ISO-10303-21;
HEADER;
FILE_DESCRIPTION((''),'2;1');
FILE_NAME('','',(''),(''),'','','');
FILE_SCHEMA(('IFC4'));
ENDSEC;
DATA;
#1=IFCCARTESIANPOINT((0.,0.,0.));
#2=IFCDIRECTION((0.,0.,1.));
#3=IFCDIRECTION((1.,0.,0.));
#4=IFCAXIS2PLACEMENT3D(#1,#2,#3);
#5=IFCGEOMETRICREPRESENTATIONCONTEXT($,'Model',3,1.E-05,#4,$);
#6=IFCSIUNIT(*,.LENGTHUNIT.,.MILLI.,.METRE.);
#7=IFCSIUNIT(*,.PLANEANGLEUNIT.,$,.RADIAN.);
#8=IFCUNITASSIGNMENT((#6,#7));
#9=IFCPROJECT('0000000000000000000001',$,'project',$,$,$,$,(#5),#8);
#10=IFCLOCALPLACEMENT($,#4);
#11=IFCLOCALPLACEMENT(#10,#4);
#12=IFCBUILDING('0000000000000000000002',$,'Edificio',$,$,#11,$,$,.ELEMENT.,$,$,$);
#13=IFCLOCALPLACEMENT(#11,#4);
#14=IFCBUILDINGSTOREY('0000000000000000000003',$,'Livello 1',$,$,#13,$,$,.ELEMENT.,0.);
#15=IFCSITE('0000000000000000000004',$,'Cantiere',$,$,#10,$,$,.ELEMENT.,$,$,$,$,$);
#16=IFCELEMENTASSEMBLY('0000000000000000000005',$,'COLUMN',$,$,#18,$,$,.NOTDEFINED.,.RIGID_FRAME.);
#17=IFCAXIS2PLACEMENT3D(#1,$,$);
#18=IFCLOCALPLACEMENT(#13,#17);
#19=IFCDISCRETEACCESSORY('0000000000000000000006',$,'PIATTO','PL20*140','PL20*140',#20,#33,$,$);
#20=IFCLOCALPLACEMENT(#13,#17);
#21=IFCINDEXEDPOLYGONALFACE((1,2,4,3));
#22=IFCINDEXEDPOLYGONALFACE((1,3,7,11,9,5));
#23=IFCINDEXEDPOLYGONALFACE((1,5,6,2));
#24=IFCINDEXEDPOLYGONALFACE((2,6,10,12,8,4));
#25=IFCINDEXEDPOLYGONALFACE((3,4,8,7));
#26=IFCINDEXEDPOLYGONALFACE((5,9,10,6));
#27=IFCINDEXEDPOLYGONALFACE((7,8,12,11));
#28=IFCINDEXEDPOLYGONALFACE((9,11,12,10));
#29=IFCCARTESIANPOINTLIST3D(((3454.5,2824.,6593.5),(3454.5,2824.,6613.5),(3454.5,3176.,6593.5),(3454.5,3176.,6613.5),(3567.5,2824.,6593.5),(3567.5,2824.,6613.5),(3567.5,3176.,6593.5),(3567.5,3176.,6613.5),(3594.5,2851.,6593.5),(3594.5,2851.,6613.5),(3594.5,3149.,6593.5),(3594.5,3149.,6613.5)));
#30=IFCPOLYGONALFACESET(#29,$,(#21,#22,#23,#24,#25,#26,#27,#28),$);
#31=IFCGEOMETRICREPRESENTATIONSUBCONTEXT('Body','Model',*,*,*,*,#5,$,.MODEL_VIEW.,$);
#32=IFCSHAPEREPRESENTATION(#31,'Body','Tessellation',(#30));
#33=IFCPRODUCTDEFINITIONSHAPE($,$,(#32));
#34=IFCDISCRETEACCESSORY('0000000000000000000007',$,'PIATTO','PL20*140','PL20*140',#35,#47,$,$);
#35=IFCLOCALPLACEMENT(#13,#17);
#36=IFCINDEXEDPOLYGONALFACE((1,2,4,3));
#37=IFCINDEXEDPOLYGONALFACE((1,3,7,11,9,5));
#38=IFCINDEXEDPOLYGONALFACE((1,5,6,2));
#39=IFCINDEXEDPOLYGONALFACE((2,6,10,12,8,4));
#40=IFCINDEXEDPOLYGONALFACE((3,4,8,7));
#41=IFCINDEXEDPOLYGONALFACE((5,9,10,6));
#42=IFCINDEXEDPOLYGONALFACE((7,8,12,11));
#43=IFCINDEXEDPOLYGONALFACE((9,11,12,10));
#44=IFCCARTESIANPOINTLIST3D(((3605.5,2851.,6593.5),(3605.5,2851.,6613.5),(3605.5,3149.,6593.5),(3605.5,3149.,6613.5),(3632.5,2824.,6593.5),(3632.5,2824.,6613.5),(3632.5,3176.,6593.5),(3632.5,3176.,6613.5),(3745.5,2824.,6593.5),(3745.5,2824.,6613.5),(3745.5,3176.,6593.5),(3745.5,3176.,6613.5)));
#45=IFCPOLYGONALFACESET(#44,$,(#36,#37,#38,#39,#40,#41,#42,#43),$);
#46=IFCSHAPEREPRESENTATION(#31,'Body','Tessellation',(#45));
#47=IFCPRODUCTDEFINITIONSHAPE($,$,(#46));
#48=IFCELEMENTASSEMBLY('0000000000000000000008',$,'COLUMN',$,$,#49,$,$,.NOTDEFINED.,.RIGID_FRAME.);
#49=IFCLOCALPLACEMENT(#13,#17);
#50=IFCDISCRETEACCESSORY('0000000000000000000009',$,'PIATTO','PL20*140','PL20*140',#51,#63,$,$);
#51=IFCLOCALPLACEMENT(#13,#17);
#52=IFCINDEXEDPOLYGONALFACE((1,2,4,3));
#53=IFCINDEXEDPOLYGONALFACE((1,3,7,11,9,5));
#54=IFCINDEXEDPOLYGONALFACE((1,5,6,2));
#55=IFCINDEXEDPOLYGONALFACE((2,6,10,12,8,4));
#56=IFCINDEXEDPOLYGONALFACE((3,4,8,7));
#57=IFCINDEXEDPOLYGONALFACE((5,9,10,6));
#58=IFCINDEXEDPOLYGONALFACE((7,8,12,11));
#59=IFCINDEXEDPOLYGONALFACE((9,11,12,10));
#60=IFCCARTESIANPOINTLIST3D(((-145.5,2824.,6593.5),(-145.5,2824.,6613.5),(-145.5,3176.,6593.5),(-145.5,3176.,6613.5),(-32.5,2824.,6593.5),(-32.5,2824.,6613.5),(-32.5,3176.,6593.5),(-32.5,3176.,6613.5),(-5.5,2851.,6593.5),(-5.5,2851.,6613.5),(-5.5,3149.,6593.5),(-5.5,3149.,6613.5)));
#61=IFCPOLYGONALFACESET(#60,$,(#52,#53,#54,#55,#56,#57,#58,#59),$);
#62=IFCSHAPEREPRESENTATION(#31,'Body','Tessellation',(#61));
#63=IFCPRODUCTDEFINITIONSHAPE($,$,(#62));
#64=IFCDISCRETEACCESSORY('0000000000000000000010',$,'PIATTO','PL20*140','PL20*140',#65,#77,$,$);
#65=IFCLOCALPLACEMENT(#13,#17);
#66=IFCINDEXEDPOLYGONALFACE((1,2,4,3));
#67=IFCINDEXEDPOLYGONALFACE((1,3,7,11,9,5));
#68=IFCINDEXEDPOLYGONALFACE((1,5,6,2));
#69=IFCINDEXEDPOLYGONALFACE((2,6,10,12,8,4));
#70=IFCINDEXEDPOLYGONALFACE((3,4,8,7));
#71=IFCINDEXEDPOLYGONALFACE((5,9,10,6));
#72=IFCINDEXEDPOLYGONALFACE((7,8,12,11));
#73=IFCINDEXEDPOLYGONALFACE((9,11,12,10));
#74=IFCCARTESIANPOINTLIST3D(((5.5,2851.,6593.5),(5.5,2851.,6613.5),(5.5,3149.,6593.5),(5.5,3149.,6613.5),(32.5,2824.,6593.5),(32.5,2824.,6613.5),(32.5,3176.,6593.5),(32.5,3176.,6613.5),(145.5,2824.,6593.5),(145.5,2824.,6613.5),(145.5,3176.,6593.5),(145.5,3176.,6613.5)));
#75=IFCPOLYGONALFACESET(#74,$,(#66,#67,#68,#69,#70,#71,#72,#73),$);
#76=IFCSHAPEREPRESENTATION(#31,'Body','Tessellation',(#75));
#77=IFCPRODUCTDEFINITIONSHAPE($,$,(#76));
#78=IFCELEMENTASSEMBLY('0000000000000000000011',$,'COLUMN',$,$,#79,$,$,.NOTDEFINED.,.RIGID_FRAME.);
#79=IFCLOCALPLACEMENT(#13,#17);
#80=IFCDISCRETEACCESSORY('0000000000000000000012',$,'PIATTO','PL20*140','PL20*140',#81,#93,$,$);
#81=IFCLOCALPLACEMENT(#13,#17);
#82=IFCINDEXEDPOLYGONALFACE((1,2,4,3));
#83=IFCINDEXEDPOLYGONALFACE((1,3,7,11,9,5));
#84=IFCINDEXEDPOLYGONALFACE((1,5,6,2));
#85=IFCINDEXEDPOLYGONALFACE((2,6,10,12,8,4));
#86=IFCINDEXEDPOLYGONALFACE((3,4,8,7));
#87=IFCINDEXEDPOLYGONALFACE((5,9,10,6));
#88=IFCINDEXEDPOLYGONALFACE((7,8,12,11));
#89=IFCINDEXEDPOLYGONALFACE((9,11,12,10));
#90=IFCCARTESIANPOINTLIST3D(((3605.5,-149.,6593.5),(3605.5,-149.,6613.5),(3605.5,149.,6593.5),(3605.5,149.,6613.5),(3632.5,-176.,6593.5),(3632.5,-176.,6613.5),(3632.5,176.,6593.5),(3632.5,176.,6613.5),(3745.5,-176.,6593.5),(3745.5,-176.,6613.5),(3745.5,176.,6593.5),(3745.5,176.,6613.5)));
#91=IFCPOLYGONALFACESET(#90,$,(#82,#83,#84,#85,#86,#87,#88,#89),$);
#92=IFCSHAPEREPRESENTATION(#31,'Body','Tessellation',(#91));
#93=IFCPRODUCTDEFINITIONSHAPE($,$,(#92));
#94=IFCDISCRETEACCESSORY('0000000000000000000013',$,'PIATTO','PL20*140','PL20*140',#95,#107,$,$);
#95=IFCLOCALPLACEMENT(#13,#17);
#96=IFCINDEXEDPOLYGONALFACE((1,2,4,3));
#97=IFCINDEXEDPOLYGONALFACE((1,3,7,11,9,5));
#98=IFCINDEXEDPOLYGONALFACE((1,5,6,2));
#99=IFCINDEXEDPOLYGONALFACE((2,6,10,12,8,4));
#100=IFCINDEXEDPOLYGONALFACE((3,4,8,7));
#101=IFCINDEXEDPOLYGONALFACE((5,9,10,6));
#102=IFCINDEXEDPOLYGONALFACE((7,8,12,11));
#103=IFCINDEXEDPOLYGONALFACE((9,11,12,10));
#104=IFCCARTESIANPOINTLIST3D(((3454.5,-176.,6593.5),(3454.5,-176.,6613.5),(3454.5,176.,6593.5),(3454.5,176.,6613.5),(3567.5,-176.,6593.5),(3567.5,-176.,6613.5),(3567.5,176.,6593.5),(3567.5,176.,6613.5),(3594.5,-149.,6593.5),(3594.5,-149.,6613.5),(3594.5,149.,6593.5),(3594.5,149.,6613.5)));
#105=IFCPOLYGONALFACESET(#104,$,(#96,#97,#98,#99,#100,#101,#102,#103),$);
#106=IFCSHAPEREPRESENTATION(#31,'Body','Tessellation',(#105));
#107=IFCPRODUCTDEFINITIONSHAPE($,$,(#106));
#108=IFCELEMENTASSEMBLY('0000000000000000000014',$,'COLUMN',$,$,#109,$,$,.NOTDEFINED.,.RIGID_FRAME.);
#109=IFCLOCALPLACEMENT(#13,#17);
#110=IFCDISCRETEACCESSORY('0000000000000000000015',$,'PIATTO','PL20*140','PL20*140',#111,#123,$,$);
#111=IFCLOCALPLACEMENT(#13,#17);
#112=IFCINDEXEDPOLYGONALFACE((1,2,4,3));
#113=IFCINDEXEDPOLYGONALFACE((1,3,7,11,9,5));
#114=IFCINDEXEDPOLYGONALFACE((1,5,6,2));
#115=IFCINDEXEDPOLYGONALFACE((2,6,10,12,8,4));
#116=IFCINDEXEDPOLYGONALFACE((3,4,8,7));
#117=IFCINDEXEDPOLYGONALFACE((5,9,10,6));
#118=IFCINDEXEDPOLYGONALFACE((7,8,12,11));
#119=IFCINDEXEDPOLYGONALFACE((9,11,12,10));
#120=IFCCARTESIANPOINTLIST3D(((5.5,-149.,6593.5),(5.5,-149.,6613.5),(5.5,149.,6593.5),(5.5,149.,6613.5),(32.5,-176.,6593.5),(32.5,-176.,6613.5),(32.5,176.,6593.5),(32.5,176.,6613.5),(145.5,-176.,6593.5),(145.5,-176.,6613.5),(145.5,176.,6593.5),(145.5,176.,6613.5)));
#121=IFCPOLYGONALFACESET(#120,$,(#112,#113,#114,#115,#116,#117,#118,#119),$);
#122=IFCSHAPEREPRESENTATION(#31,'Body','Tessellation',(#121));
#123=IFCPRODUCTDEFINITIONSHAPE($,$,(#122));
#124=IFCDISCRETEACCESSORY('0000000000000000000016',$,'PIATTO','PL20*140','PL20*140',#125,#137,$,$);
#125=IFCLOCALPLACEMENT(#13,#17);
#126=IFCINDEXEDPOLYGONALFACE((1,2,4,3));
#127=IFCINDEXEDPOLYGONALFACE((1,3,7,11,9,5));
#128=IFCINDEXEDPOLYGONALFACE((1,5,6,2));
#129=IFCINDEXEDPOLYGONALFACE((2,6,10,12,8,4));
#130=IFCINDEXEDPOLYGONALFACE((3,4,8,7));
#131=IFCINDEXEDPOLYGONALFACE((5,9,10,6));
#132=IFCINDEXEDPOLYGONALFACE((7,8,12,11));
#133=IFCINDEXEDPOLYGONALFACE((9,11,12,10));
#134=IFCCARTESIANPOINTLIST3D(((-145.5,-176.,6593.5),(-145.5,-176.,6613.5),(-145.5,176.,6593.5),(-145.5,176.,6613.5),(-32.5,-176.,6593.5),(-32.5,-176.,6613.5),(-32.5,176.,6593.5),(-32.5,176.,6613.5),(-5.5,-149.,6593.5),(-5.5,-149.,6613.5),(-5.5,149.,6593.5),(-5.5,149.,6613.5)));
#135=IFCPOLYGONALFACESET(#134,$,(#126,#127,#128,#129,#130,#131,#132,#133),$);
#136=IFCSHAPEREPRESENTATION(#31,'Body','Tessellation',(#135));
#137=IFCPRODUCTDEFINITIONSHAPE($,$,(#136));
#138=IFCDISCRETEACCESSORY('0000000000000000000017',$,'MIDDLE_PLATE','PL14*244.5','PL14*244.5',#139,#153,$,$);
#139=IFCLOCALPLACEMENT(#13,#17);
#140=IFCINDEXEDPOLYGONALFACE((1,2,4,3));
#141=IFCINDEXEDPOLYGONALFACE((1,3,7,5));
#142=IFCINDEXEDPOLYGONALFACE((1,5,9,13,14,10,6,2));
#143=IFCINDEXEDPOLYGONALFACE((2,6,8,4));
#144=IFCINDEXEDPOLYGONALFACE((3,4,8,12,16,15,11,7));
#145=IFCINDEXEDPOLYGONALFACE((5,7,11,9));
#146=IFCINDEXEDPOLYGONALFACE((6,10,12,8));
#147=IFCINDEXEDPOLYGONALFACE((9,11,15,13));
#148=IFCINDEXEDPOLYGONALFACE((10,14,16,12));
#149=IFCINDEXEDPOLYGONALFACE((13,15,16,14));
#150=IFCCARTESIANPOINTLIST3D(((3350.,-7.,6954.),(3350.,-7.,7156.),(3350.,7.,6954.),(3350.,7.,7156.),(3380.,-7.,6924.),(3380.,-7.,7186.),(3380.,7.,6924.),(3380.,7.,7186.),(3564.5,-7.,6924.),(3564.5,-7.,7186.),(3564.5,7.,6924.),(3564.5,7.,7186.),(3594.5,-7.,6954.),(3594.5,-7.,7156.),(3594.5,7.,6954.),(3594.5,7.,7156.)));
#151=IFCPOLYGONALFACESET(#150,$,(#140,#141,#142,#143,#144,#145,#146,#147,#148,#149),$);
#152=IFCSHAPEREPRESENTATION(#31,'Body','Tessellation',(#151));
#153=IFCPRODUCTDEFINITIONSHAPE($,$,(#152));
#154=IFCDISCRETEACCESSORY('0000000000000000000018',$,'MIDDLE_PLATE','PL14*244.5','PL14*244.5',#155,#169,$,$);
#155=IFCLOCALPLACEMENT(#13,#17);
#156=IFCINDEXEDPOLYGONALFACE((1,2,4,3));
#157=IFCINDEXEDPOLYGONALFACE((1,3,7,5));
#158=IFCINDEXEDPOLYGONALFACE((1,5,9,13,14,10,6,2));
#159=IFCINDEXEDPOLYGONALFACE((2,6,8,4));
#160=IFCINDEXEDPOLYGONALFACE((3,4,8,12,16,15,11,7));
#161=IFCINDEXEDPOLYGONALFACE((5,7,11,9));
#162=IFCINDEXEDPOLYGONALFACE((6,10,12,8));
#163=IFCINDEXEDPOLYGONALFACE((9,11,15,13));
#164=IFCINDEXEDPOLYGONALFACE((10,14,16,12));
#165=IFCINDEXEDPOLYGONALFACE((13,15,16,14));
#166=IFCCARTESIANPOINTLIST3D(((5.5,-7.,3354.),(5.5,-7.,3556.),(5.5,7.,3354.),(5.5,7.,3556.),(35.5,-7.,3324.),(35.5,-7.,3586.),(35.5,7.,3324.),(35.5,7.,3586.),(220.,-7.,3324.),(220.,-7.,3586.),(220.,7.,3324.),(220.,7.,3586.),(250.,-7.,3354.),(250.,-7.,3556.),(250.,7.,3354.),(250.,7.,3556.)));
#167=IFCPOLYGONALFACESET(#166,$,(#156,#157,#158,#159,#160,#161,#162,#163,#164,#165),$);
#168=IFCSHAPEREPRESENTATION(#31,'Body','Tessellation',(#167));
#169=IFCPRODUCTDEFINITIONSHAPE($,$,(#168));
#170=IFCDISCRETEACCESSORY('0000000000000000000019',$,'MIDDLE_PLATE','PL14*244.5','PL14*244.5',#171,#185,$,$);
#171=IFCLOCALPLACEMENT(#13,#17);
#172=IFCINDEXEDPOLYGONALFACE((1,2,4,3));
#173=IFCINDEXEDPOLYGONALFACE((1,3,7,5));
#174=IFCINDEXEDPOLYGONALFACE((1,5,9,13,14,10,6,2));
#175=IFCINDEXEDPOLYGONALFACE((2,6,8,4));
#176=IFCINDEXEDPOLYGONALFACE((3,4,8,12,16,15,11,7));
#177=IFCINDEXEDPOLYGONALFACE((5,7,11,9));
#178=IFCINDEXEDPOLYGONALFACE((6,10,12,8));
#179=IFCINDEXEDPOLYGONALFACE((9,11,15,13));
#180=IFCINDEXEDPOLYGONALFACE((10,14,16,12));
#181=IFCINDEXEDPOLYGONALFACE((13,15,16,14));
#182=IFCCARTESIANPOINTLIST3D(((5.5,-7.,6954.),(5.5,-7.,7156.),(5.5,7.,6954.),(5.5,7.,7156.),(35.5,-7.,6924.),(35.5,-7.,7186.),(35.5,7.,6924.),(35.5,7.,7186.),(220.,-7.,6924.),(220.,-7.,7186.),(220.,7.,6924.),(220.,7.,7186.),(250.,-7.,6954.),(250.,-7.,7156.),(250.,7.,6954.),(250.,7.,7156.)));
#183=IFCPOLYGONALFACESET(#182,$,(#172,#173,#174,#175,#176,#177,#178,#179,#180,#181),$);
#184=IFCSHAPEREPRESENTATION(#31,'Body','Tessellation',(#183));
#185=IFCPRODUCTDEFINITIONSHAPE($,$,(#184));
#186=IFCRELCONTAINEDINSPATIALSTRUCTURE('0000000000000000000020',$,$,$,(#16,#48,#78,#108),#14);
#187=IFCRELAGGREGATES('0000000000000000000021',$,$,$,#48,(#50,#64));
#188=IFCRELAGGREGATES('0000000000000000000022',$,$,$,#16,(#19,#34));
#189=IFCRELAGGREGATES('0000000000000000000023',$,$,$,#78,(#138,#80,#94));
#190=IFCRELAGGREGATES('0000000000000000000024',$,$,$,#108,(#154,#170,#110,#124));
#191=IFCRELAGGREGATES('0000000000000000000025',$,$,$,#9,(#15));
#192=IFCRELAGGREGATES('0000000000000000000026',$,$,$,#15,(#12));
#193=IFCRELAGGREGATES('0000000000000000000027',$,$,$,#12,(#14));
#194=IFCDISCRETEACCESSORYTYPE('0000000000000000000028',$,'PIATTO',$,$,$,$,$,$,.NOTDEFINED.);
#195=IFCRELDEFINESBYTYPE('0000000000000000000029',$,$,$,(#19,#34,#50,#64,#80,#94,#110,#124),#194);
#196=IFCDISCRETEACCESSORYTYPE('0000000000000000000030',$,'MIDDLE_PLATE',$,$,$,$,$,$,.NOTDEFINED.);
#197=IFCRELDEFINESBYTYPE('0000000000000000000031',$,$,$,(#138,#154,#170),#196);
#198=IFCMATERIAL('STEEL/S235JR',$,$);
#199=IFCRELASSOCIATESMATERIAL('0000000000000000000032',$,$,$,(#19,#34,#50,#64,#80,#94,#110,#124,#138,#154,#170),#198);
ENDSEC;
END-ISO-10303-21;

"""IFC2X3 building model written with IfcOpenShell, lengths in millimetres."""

from ifc_helpers import new_model, si_unit, frame, origin_with_axes, place, context, subcontext, project, spatial, polyline, outline, extrude, material, type_object, element, aggregate, save


model = new_model("IFC2X3")

# Units and contexts
model_context = context("Model", 3, precision=1e-05, world=origin_with_axes())
body_context = subcontext(model_context, "Body", "Model", "MODEL_VIEW")
ifc_project = project(units=[si_unit("LENGTHUNIT", "METRE", prefix="MILLI"), si_unit("PLANEANGLEUNIT", "RADIAN")], contexts=[model_context])

# Site, building, storey
site_placement = place(None, origin_with_axes())
site = spatial("IfcSite", under=ifc_project, at=site_placement, Name="Cantiere", CompositionType="ELEMENT")
building_placement = place(site_placement, origin_with_axes())
building = spatial("IfcBuilding", under=site, at=building_placement, Name="Edificio", CompositionType="ELEMENT")
storey_placement = place(building_placement, origin_with_axes())
storey = spatial("IfcBuildingStorey", under=building, at=storey_placement, Name="Livello 1", CompositionType="ELEMENT", Elevation=0.0)

# Element assemblies, discrete accessories
assembly_1_placement = place(storey_placement, origin_with_axes())
assembly_1 = element("IfcElementAssembly", 1, at=assembly_1_placement, inside=storey, Name="COLUMN", AssemblyPlace="NOTDEFINED", PredefinedType="RIGID_FRAME")
ifc_material = material(Name="STEEL/S235JR")
discrete_accessory_type_1 = type_object("IfcDiscreteAccessoryType", Name="PIATTO")
discrete_accessory_1_placement = place(assembly_1_placement, frame((3454.5, 2824.0, 6603.5), z_axis=(0.0, 0.0, 1.0), x_axis=(1.0, 0.0, 0.0)))
discrete_accessory_1 = element("IfcDiscreteAccessory", 2, at=discrete_accessory_1_placement, type_object=discrete_accessory_type_1, material=ifc_material, Name="PIATTO", Description="PL20*140", ObjectType="PL20*140", context=body_context, shape_type="SweptSolid", body=[
    extrude(outline(polyline([(0.0, 0.0), (113.0, 0.0), (140.0, 27.0), (140.0, 325.0), (113.0, 352.0), (0.0, 352.0), (0.0, 0.0)])), frame((0.0, 0.0, -10.0), z_axis=(0.0, 0.0, 1.0), x_axis=(1.0, 0.0, 0.0)), (0.0, 0.0, 1.0), 20.0),
])
discrete_accessory_2_placement = place(assembly_1_placement, frame((3745.5, 2824.0, 6603.5), z_axis=(0.0, 0.0, -1.0), x_axis=(-1.0, 0.0, 0.0)))
discrete_accessory_2 = element("IfcDiscreteAccessory", 3, at=discrete_accessory_2_placement, type_object=discrete_accessory_type_1, material=ifc_material, Name="PIATTO", Description="PL20*140", ObjectType="PL20*140", context=body_context, shape_type="SweptSolid", body=[
    extrude(outline(polyline([(0.0, 0.0), (113.0, 0.0), (140.0, 27.0), (140.0, 325.0), (113.0, 352.0), (0.0, 352.0), (0.0, 0.0)])), frame((0.0, 0.0, -10.0), z_axis=(0.0, 0.0, 1.0), x_axis=(1.0, 0.0, 0.0)), (0.0, 0.0, 1.0), 20.0),
])
assembly_2_placement = place(storey_placement, origin_with_axes())
assembly_2 = element("IfcElementAssembly", 4, at=assembly_2_placement, inside=storey, Name="COLUMN", AssemblyPlace="NOTDEFINED", PredefinedType="RIGID_FRAME")
discrete_accessory_3_placement = place(assembly_2_placement, frame((-145.5, 2824.0, 6603.5), z_axis=(0.0, 0.0, 1.0), x_axis=(1.0, 0.0, 0.0)))
discrete_accessory_3 = element("IfcDiscreteAccessory", 5, at=discrete_accessory_3_placement, type_object=discrete_accessory_type_1, material=ifc_material, Name="PIATTO", Description="PL20*140", ObjectType="PL20*140", context=body_context, shape_type="SweptSolid", body=[
    extrude(outline(polyline([(0.0, 0.0), (113.0, 0.0), (140.0, 27.0), (140.0, 325.0), (113.0, 352.0), (0.0, 352.0), (0.0, 0.0)])), frame((0.0, 0.0, -10.0), z_axis=(0.0, 0.0, 1.0), x_axis=(1.0, 0.0, 0.0)), (0.0, 0.0, 1.0), 20.0),
])
discrete_accessory_4_placement = place(assembly_2_placement, frame((145.5, 2824.0, 6603.5), z_axis=(0.0, 0.0, -1.0), x_axis=(-1.0, 0.0, 0.0)))
discrete_accessory_4 = element("IfcDiscreteAccessory", 6, at=discrete_accessory_4_placement, type_object=discrete_accessory_type_1, material=ifc_material, Name="PIATTO", Description="PL20*140", ObjectType="PL20*140", context=body_context, shape_type="SweptSolid", body=[
    extrude(outline(polyline([(0.0, 0.0), (113.0, 0.0), (140.0, 27.0), (140.0, 325.0), (113.0, 352.0), (0.0, 352.0), (0.0, 0.0)])), frame((0.0, 0.0, -10.0), z_axis=(0.0, 0.0, 1.0), x_axis=(1.0, 0.0, 0.0)), (0.0, 0.0, 1.0), 20.0),
])
aggregate(assembly_2, [discrete_accessory_3, discrete_accessory_4])
assembly_3_placement = place(storey_placement, origin_with_axes())
assembly_3 = element("IfcElementAssembly", 7, at=assembly_3_placement, inside=storey, Name="COLUMN", AssemblyPlace="NOTDEFINED", PredefinedType="RIGID_FRAME")
discrete_accessory_5_placement = place(assembly_3_placement, frame((3745.5, 176.0, 6603.5), z_axis=(0.0, 0.0, 1.0), x_axis=(-1.0, 0.0, 0.0)))
discrete_accessory_5 = element("IfcDiscreteAccessory", 8, at=discrete_accessory_5_placement, type_object=discrete_accessory_type_1, material=ifc_material, Name="PIATTO", Description="PL20*140", ObjectType="PL20*140", context=body_context, shape_type="SweptSolid", body=[
    extrude(outline(polyline([(0.0, 0.0), (113.0, 0.0), (140.0, 27.0), (140.0, 325.0), (113.0, 352.0), (0.0, 352.0), (0.0, 0.0)])), frame((0.0, 0.0, -10.0), z_axis=(0.0, 0.0, 1.0), x_axis=(1.0, 0.0, 0.0)), (0.0, 0.0, 1.0), 20.0),
])
discrete_accessory_6_placement = place(assembly_3_placement, frame((3454.5, 176.0, 6603.5), z_axis=(0.0, 0.0, -1.0), x_axis=(1.0, 0.0, 0.0)))
discrete_accessory_6 = element("IfcDiscreteAccessory", 9, at=discrete_accessory_6_placement, type_object=discrete_accessory_type_1, material=ifc_material, Name="PIATTO", Description="PL20*140", ObjectType="PL20*140", context=body_context, shape_type="SweptSolid", body=[
    extrude(outline(polyline([(0.0, 0.0), (113.0, 0.0), (140.0, 27.0), (140.0, 325.0), (113.0, 352.0), (0.0, 352.0), (0.0, 0.0)])), frame((0.0, 0.0, -10.0), z_axis=(0.0, 0.0, 1.0), x_axis=(1.0, 0.0, 0.0)), (0.0, 0.0, 1.0), 20.0),
])
assembly_4_placement = place(storey_placement, origin_with_axes())
assembly_4 = element("IfcElementAssembly", 10, at=assembly_4_placement, inside=storey, Name="COLUMN", AssemblyPlace="NOTDEFINED", PredefinedType="RIGID_FRAME")
discrete_accessory_7_placement = place(assembly_4_placement, frame((145.5, 176.0, 6603.5), z_axis=(0.0, 0.0, 1.0), x_axis=(-1.0, 0.0, 0.0)))
discrete_accessory_7 = element("IfcDiscreteAccessory", 11, at=discrete_accessory_7_placement, type_object=discrete_accessory_type_1, material=ifc_material, Name="PIATTO", Description="PL20*140", ObjectType="PL20*140", context=body_context, shape_type="SweptSolid", body=[
    extrude(outline(polyline([(0.0, 0.0), (113.0, 0.0), (140.0, 27.0), (140.0, 325.0), (113.0, 352.0), (0.0, 352.0), (0.0, 0.0)])), frame((0.0, 0.0, -10.0), z_axis=(0.0, 0.0, 1.0), x_axis=(1.0, 0.0, 0.0)), (0.0, 0.0, 1.0), 20.0),
])
discrete_accessory_8_placement = place(assembly_4_placement, frame((-145.5, 176.0, 6603.5), z_axis=(0.0, 0.0, -1.0), x_axis=(1.0, 0.0, 0.0)))
discrete_accessory_8 = element("IfcDiscreteAccessory", 12, at=discrete_accessory_8_placement, type_object=discrete_accessory_type_1, material=ifc_material, Name="PIATTO", Description="PL20*140", ObjectType="PL20*140", context=body_context, shape_type="SweptSolid", body=[
    extrude(outline(polyline([(0.0, 0.0), (113.0, 0.0), (140.0, 27.0), (140.0, 325.0), (113.0, 352.0), (0.0, 352.0), (0.0, 0.0)])), frame((0.0, 0.0, -10.0), z_axis=(0.0, 0.0, 1.0), x_axis=(1.0, 0.0, 0.0)), (0.0, 0.0, 1.0), 20.0),
])

# Discrete accessories
discrete_accessory_type_2 = type_object("IfcDiscreteAccessoryType", Name="MIDDLE_PLATE")
discrete_accessory_9_placement = place(assembly_3_placement, frame((3350.0, 0.0, 7186.0), z_axis=(0.0, 1.0, 0.0), x_axis=(1.0, 0.0, 0.0)))
discrete_accessory_9 = element("IfcDiscreteAccessory", 13, at=discrete_accessory_9_placement, type_object=discrete_accessory_type_2, material=ifc_material, Name="MIDDLE_PLATE", Description="PL14*244.5", ObjectType="PL14*244.5", context=body_context, shape_type="SweptSolid", body=[
    extrude(outline(polyline([(0.0, 30.0), (30.0, 0.0), (214.5, 0.0), (244.5, 30.0), (244.5, 232.0), (214.5, 262.0), (30.0, 262.0), (0.0, 232.0), (0.0, 30.0)])), frame((0.0, 0.0, -7.0), z_axis=(0.0, 0.0, 1.0), x_axis=(1.0, 0.0, 0.0)), (0.0, 0.0, 1.0), 14.0),
])
discrete_accessory_10_placement = place(assembly_4_placement, frame((250.0, 0.0, 3586.0), z_axis=(0.0, -1.0, 0.0), x_axis=(-1.0, 0.0, 0.0)))
discrete_accessory_10 = element("IfcDiscreteAccessory", 14, at=discrete_accessory_10_placement, type_object=discrete_accessory_type_2, material=ifc_material, Name="MIDDLE_PLATE", Description="PL14*244.5", ObjectType="PL14*244.5", context=body_context, shape_type="SweptSolid", body=[
    extrude(outline(polyline([(0.0, 30.0), (30.0, 0.0), (214.5, 0.0), (244.5, 30.0), (244.5, 232.0), (214.5, 262.0), (30.0, 262.0), (0.0, 232.0), (0.0, 30.0)])), frame((0.0, 0.0, -7.0), z_axis=(0.0, 0.0, 1.0), x_axis=(1.0, 0.0, 0.0)), (0.0, 0.0, 1.0), 14.0),
])
discrete_accessory_11_placement = place(assembly_4_placement, frame((250.0, 0.0, 7186.0), z_axis=(0.0, -1.0, 0.0), x_axis=(-1.0, 0.0, 0.0)))
discrete_accessory_11 = element("IfcDiscreteAccessory", 15, at=discrete_accessory_11_placement, type_object=discrete_accessory_type_2, material=ifc_material, Name="MIDDLE_PLATE", Description="PL14*244.5", ObjectType="PL14*244.5", context=body_context, shape_type="SweptSolid", body=[
    extrude(outline(polyline([(0.0, 30.0), (30.0, 0.0), (214.5, 0.0), (244.5, 30.0), (244.5, 232.0), (214.5, 262.0), (30.0, 262.0), (0.0, 232.0), (0.0, 30.0)])), frame((0.0, 0.0, -7.0), z_axis=(0.0, 0.0, 1.0), x_axis=(1.0, 0.0, 0.0)), (0.0, 0.0, 1.0), 14.0),
])
aggregate(assembly_1, [discrete_accessory_1, discrete_accessory_2])
aggregate(assembly_3, [discrete_accessory_9, discrete_accessory_5, discrete_accessory_6])
aggregate(assembly_4, [discrete_accessory_10, discrete_accessory_11, discrete_accessory_7, discrete_accessory_8])

save(model, "model.ifc")
